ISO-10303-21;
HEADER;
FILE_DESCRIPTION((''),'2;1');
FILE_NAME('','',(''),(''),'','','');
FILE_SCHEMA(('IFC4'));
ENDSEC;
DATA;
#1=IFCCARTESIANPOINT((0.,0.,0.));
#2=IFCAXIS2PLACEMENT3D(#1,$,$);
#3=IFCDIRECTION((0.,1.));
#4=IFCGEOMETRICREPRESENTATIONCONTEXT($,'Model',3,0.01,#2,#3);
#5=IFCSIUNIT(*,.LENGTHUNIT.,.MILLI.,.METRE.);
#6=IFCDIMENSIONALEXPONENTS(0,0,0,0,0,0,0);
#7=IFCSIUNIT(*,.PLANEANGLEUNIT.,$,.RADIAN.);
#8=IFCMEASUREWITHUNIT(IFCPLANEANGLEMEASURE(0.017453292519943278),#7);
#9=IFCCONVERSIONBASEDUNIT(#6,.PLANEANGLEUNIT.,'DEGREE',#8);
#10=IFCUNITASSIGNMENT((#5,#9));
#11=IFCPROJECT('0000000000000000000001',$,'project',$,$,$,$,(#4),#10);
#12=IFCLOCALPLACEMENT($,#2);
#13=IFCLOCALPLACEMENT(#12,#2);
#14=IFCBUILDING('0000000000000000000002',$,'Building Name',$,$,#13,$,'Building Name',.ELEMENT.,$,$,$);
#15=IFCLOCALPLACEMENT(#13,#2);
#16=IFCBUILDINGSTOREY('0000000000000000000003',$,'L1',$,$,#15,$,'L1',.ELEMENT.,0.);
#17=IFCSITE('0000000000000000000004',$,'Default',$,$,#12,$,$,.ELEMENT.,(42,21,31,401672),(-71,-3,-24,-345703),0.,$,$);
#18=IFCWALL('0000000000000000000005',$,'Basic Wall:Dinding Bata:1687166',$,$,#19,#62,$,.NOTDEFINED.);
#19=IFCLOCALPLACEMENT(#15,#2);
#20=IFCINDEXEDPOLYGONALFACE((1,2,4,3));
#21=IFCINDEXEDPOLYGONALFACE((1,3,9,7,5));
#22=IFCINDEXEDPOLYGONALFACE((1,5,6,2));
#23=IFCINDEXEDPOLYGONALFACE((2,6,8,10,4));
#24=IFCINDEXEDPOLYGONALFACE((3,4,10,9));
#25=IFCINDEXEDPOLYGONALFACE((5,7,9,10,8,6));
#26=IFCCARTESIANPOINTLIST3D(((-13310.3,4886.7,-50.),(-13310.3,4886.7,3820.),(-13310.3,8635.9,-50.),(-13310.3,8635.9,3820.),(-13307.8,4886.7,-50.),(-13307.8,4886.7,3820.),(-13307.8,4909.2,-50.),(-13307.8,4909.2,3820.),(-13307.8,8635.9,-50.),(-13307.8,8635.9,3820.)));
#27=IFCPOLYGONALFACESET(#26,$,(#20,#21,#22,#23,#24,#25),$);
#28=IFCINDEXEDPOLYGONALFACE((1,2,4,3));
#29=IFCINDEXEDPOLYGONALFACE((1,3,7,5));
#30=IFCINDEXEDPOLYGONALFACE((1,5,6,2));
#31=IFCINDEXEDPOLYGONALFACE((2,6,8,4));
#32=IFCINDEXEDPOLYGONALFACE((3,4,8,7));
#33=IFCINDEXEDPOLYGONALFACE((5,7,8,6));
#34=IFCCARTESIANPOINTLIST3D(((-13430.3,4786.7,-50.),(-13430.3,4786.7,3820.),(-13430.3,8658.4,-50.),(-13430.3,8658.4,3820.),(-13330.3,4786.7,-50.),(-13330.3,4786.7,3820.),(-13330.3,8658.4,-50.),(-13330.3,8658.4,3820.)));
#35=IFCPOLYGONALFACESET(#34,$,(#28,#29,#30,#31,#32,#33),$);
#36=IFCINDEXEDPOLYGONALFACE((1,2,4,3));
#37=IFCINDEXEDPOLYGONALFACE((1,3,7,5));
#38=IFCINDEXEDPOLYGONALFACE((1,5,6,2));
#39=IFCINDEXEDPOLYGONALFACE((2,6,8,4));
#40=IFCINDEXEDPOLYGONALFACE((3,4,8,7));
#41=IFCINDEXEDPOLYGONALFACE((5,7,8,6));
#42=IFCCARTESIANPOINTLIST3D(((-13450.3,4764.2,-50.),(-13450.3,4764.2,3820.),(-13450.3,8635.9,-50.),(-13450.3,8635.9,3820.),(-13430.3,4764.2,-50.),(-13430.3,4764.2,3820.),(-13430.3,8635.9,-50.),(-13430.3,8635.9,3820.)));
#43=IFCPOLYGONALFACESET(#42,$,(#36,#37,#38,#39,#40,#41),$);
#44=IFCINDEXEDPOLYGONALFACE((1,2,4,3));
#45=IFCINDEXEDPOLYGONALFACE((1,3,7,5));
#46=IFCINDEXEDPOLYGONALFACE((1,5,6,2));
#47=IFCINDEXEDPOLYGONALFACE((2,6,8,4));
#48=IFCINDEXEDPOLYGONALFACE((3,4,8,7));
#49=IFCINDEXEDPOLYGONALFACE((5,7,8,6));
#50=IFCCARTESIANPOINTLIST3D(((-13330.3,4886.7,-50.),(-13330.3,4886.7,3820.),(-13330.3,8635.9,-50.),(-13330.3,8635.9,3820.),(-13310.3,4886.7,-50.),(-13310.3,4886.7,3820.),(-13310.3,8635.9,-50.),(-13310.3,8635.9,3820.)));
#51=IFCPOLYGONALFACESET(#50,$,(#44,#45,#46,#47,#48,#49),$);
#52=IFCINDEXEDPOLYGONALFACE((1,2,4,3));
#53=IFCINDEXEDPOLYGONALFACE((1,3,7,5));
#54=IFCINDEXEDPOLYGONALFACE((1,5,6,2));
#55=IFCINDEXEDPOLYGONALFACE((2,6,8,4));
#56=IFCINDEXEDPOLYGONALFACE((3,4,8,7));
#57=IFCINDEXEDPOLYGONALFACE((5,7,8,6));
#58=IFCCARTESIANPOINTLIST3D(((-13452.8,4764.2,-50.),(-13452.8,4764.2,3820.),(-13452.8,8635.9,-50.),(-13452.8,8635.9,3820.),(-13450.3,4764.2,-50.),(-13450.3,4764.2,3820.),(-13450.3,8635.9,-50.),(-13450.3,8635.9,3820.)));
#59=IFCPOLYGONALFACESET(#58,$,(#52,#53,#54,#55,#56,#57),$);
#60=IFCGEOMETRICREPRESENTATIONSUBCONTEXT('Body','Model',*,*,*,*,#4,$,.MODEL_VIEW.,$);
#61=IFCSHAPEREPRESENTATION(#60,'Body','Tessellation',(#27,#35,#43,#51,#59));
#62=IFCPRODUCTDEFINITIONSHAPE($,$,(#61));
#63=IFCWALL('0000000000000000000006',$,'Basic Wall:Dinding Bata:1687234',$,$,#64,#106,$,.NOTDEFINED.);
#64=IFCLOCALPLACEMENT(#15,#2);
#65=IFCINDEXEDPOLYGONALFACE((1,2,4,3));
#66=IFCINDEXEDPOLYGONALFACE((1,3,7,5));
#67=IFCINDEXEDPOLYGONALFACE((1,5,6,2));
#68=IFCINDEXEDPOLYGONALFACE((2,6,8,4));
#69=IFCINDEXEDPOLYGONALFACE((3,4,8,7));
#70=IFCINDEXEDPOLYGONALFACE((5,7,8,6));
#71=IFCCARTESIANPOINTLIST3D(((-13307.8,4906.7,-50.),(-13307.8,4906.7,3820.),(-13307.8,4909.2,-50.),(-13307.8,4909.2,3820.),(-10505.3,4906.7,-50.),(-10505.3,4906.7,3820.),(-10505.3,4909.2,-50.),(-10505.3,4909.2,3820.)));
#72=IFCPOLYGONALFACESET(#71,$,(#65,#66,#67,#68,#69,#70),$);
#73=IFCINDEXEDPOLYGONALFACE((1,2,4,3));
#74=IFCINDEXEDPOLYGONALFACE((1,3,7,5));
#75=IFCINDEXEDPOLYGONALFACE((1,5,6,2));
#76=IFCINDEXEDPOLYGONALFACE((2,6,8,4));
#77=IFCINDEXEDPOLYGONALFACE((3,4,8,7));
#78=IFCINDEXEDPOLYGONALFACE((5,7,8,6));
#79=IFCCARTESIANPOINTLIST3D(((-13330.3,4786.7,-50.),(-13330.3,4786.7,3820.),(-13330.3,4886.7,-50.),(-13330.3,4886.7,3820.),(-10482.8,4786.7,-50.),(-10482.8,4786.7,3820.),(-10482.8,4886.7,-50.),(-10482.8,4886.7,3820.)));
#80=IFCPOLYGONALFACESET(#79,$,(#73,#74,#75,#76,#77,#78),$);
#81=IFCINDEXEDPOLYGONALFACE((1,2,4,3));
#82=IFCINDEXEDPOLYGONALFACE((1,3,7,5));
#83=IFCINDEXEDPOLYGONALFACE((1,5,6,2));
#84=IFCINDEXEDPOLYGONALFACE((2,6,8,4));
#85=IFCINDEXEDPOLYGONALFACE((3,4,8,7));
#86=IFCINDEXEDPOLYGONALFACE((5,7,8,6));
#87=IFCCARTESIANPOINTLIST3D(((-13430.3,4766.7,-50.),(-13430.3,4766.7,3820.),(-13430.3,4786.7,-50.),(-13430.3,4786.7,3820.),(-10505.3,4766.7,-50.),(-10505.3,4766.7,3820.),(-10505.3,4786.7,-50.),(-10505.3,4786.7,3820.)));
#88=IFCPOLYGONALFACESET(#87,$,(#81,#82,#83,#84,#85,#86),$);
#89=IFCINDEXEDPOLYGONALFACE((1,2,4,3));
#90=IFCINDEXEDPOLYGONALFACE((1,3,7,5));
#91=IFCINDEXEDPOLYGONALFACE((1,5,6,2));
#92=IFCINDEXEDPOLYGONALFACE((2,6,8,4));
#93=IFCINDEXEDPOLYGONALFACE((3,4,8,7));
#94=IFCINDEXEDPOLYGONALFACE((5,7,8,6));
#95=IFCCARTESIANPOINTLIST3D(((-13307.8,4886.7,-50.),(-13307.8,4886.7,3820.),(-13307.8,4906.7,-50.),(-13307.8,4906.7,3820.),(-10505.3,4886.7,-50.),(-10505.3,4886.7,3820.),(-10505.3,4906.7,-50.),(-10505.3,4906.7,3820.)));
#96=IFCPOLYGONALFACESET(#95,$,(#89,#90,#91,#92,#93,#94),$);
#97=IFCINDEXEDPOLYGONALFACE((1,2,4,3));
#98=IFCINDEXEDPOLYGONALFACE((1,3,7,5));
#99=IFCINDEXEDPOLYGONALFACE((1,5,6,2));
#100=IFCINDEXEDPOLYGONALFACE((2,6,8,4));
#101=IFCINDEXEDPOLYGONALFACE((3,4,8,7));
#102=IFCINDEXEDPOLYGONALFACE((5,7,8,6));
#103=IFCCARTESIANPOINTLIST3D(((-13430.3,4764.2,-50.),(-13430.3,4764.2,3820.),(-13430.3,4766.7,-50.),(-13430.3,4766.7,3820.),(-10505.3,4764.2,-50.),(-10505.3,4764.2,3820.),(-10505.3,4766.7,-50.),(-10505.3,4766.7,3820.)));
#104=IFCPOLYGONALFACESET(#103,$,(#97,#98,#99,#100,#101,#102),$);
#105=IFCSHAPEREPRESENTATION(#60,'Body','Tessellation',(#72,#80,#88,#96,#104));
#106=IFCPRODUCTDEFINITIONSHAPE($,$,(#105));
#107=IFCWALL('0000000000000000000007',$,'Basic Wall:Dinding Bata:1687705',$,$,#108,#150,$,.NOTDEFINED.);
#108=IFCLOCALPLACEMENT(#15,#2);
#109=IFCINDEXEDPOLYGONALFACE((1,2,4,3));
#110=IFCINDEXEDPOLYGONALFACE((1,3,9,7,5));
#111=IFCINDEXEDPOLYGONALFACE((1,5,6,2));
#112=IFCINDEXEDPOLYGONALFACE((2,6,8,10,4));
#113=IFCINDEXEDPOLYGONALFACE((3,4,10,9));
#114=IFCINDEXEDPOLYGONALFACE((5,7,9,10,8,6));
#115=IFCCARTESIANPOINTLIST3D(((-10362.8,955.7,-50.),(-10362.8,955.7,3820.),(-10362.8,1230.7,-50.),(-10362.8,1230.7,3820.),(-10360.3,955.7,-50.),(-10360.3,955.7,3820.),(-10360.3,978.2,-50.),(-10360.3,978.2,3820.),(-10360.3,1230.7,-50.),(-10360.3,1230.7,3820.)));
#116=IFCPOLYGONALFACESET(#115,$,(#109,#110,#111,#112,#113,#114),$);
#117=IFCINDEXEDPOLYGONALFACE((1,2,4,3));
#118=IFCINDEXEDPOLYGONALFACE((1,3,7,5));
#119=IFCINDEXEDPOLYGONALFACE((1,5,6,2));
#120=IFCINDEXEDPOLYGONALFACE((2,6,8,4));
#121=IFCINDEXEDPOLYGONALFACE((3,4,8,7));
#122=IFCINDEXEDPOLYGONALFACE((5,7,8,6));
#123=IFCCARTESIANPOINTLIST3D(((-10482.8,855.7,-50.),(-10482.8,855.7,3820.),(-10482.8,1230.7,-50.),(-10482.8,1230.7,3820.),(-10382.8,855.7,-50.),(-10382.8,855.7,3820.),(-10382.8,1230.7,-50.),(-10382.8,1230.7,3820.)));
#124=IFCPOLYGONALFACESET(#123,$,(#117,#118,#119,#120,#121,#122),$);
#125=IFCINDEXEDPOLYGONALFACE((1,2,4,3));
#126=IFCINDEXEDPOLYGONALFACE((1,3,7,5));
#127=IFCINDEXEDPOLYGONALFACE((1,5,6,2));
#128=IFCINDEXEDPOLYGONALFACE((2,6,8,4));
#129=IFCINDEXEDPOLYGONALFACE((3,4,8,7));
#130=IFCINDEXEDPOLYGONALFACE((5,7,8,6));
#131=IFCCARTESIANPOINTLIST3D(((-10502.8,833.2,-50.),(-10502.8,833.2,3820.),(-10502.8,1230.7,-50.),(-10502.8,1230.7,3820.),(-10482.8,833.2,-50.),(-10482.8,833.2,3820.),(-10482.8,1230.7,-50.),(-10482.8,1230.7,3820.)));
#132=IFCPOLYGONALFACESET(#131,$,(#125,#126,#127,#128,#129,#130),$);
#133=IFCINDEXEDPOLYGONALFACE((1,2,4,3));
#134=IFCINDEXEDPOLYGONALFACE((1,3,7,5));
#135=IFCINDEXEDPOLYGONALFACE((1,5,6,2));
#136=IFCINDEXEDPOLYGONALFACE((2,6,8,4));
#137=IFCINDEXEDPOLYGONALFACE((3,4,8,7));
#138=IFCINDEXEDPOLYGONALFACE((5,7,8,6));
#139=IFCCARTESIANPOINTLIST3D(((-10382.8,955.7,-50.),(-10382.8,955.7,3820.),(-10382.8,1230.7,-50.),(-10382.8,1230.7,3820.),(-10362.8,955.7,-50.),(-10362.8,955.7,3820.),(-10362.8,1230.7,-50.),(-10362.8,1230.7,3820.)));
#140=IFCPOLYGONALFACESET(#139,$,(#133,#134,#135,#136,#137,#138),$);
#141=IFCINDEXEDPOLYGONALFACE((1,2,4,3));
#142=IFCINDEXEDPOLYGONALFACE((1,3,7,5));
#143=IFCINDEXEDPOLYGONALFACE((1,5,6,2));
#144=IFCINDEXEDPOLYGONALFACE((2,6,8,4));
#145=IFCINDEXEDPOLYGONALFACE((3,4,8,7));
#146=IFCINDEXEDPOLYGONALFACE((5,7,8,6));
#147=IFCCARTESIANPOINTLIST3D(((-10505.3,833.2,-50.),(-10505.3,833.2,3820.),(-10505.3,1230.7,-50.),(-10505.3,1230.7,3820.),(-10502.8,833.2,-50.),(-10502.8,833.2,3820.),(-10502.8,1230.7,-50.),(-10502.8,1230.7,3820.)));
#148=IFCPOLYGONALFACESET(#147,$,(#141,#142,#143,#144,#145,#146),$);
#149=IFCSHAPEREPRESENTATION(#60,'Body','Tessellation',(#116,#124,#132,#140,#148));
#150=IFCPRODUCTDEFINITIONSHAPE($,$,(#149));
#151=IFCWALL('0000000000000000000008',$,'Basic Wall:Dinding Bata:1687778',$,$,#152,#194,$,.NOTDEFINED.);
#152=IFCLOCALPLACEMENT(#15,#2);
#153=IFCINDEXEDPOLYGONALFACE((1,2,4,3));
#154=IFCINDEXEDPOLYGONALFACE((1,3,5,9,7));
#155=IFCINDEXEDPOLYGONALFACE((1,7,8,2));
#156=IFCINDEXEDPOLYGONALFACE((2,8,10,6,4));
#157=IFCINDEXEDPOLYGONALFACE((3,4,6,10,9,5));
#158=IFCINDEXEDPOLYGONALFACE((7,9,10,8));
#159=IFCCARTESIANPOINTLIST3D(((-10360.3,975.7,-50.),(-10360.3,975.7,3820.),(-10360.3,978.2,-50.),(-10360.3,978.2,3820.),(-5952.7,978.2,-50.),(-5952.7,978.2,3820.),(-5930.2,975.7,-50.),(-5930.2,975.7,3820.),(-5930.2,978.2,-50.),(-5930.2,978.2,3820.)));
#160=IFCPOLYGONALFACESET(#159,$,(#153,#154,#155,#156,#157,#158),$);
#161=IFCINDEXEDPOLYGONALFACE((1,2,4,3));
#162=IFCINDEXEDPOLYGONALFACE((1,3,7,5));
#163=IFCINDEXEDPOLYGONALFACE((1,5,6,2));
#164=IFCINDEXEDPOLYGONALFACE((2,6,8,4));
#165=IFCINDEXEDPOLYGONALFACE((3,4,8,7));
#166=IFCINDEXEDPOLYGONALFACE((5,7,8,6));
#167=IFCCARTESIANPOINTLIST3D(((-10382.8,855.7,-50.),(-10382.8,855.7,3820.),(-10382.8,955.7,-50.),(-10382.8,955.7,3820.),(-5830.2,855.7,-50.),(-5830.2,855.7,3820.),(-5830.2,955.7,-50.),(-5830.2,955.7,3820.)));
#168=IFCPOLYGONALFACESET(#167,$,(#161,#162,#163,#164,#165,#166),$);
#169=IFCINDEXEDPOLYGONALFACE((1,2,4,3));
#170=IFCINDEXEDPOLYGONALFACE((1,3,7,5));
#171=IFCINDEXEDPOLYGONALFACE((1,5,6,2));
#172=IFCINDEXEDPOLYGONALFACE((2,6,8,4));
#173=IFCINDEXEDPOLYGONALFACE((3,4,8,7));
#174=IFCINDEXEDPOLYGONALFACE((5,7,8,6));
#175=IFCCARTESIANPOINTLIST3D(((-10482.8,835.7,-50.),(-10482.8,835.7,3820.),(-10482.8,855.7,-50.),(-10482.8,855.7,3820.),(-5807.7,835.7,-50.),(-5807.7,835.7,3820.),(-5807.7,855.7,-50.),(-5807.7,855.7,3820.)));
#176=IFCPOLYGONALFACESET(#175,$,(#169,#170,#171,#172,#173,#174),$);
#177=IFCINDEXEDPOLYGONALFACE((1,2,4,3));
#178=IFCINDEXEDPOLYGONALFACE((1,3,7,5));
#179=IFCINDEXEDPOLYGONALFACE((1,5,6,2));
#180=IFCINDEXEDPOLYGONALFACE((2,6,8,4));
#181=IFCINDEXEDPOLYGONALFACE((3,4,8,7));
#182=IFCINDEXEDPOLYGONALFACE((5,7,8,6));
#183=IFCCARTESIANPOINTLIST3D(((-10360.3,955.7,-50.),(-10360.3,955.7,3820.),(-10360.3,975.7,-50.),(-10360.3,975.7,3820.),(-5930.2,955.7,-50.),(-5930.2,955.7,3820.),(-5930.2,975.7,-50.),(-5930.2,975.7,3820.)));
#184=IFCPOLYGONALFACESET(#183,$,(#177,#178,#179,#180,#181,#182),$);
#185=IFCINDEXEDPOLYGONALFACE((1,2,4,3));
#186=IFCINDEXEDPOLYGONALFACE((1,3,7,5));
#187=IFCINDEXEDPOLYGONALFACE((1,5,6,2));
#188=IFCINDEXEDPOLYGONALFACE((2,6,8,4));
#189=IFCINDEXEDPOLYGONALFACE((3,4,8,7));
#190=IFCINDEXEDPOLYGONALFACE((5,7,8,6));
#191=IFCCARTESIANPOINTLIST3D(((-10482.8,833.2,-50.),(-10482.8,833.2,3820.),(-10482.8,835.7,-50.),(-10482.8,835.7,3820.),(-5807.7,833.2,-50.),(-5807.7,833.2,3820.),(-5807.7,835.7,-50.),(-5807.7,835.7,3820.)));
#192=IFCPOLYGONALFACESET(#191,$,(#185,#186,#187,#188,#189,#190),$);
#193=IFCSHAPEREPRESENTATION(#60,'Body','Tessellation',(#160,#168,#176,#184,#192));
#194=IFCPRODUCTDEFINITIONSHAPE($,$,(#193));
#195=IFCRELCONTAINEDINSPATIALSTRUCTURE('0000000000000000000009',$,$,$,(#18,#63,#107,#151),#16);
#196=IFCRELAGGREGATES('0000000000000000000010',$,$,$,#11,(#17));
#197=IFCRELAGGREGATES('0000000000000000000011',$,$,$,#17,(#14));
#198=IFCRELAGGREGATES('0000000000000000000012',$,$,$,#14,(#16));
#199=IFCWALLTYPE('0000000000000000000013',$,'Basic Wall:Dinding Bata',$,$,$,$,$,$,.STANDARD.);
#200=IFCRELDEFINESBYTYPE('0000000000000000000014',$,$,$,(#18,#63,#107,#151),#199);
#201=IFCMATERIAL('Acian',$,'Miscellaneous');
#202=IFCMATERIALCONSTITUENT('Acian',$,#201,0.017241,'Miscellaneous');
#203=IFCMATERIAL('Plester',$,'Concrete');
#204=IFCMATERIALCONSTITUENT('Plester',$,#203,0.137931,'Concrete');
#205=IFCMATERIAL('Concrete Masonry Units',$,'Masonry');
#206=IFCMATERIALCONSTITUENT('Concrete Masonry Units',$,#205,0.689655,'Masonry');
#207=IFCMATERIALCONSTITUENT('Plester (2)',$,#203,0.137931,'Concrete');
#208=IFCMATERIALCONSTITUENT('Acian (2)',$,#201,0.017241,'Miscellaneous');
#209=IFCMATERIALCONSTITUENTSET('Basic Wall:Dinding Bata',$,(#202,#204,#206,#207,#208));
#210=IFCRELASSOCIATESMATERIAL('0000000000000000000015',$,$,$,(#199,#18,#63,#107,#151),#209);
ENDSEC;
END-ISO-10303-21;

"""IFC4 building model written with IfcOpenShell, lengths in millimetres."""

from ifc_helpers import new_model, entity, si_unit, converted_unit, direction, frame, origin, place, context, subcontext, project, spatial, indexed_curve, outline, extrude, material, constituent, constituent_set, type_object, element, save


model = new_model("IFC4")

# Units and contexts
model_context = context("Model", 3, precision=0.01, world=origin(), true_north=direction((0.0, 1.0)))
body_context = subcontext(model_context, "Body", "Model", "MODEL_VIEW")
ifc_project = project(units=[si_unit("LENGTHUNIT", "METRE", prefix="MILLI"), converted_unit("PLANEANGLEUNIT", "DEGREE", entity("IfcPlaneAngleMeasure", 0.017453292519943278), si_unit("PLANEANGLEUNIT", "RADIAN"), dimensions=[0, 0, 0, 0, 0, 0, 0])], contexts=[model_context])

# Site, building, storey
site_placement = place(None, origin())
site = spatial("IfcSite", under=ifc_project, at=site_placement, Name="Default", CompositionType="ELEMENT", RefLatitude=(42, 21, 31, 401672), RefLongitude=(-71, -3, -24, -345703), RefElevation=0.0)
building_placement = place(site_placement, origin())
building = spatial("IfcBuilding", under=site, at=building_placement, Name="Building Name", LongName="Building Name", CompositionType="ELEMENT")
storey_placement = place(building_placement, origin())
storey = spatial("IfcBuildingStorey", under=building, at=storey_placement, Name="L1", LongName="L1", CompositionType="ELEMENT", Elevation=0.0)

# Walls
ifc_material_1 = material(Name="Acian", Category="Miscellaneous")
ifc_constituent_1 = constituent(ifc_material_1, Name="Acian", Category="Miscellaneous", fraction=0.017241)
ifc_material_2 = material(Name="Plester", Category="Concrete")
ifc_constituent_2 = constituent(ifc_material_2, Name="Plester", Category="Concrete", fraction=0.137931)
ifc_material_3 = material(Name="Concrete Masonry Units", Category="Masonry")
ifc_constituent_3 = constituent(ifc_material_3, Name="Concrete Masonry Units", Category="Masonry", fraction=0.689655)
ifc_constituent_4 = constituent(ifc_material_2, Name="Plester (2)", Category="Concrete", fraction=0.137931)
ifc_constituent_5 = constituent(ifc_material_1, Name="Acian (2)", Category="Miscellaneous", fraction=0.017241)
ifc_constituent_set = constituent_set(constituents=[ifc_constituent_1, ifc_constituent_2, ifc_constituent_3, ifc_constituent_4, ifc_constituent_5], Name="Basic Wall:Dinding Bata")
wall_type = type_object("IfcWallType", Name="Basic Wall:Dinding Bata", PredefinedType="STANDARD", material=ifc_constituent_set)
wall_1_placement = place(storey_placement, frame((-13380.3, 8635.9, -50.0), z_axis=(0.0, 0.0, 1.0), x_axis=(0.0, -1.0, 0.0)))
element("IfcWall", 1, at=wall_1_placement, inside=storey, type_object=wall_type, material=ifc_constituent_set, Name="Basic Wall:Dinding Bata:1687166", PredefinedType="NOTDEFINED", context=body_context, shape_type="SweptSolid", body=[
    extrude(outline(indexed_curve([(-1481.7, -1.0), (2245.0, -1.0), (2245.0, 1.5), (-1504.2, 1.5), (-1504.2, -1.0), (-1481.7, -1.0)], self_intersect=False)), frame((2245.0, 71.5, 0.0), z_axis=(0.0, 0.0, 1.0), x_axis=(-1.0, 0.0, 0.0)), (0.0, 0.0, 1.0), 3870.0),
    extrude(outline(indexed_curve([(-1935.8, -50.0), (1935.8, -50.0), (1935.8, 50.0), (-1935.8, 50.0), (-1935.8, -50.0)], self_intersect=False)), frame((1913.3, 0.0, 0.0)), (0.0, 0.0, 1.0), 3870.0),
    extrude(outline(indexed_curve([(-1935.8, -10.0), (1935.8, -10.0), (1935.8, 10.0), (-1935.8, 10.0), (-1935.8, -10.0)], self_intersect=False)), frame((1935.8, -60.0, 0.0)), (0.0, 0.0, 1.0), 3870.0),
    extrude(outline(indexed_curve([(-1874.6, -10.0), (1874.6, -10.0), (1874.6, 10.0), (-1874.6, 10.0), (-1874.6, -10.0)], self_intersect=False)), frame((1874.6, 60.0, 0.0)), (0.0, 0.0, 1.0), 3870.0),
    extrude(outline(indexed_curve([(-1.3, -1935.8), (1.2, -1935.8), (1.3, 1935.8), (-1.2, 1935.8), (-1.3, -1935.8)], self_intersect=False)), frame((1935.8, -71.2, 0.0), z_axis=(0.0, 0.0, 1.0), x_axis=(0.0, 1.0, 0.0)), (0.0, 0.0, 1.0), 3870.0),
])
wall_2_placement = place(storey_placement, frame((-13307.8, 4836.7, -50.0)))
element("IfcWall", 2, at=wall_2_placement, inside=storey, type_object=wall_type, material=ifc_constituent_set, Name="Basic Wall:Dinding Bata:1687234", PredefinedType="NOTDEFINED", context=body_context, shape_type="SweptSolid", body=[
    extrude(outline(indexed_curve([(-1.3, -1401.2), (1.2, -1401.2), (1.3, 1401.2), (-1.2, 1401.2), (-1.3, -1401.2)], self_intersect=False)), frame((1401.2, 71.2, 0.0), z_axis=(0.0, 0.0, 1.0), x_axis=(0.0, -1.0, 0.0)), (0.0, 0.0, 1.0), 3870.0),
    extrude(outline(indexed_curve([(-1423.7, -50.0), (1423.7, -50.0), (1423.7, 50.0), (-1423.7, 50.0), (-1423.7, -50.0)], self_intersect=False)), frame((1401.2, 0.0, 0.0)), (0.0, 0.0, 1.0), 3870.0),
    extrude(outline(indexed_curve([(-1462.5, -10.0), (1462.5, -10.0), (1462.5, 10.0), (-1462.5, 10.0), (-1462.5, -10.0)], self_intersect=False)), frame((1340.0, -60.0, 0.0)), (0.0, 0.0, 1.0), 3870.0),
    extrude(outline(indexed_curve([(-1401.2, -10.0), (1401.2, -10.0), (1401.2, 10.0), (-1401.2, 10.0), (-1401.2, -10.0)], self_intersect=False)), frame((1401.2, 60.0, 0.0)), (0.0, 0.0, 1.0), 3870.0),
    extrude(outline(indexed_curve([(-1.3, -1462.5), (1.2, -1462.5), (1.3, 1462.5), (-1.2, 1462.5), (-1.3, -1462.5)], self_intersect=False)), frame((1340.0, -71.3, 0.0), z_axis=(0.0, 0.0, 1.0), x_axis=(0.0, 1.0, 0.0)), (0.0, 0.0, 1.0), 3870.0),
])
wall_3_placement = place(storey_placement, frame((-10432.8, 1230.7, -50.0), z_axis=(0.0, 0.0, 1.0), x_axis=(0.0, -1.0, 0.0)))
element("IfcWall", 3, at=wall_3_placement, inside=storey, type_object=wall_type, material=ifc_constituent_set, Name="Basic Wall:Dinding Bata:1687705", PredefinedType="NOTDEFINED", context=body_context, shape_type="SweptSolid", body=[
    extrude(outline(indexed_curve([(-92.0, -1.0), (160.5, -1.0), (160.5, 1.5), (-114.5, 1.5), (-114.5, -1.0), (-92.0, -1.0)], self_intersect=False)), frame((160.5, 71.5, 0.0), z_axis=(0.0, 0.0, 1.0), x_axis=(-1.0, 0.0, 0.0)), (0.0, 0.0, 1.0), 3870.0),
    extrude(outline(indexed_curve([(-187.5, -50.0), (187.5, -50.0), (187.5, 50.0), (-187.5, 50.0), (-187.5, -50.0)], self_intersect=False)), frame((187.5, 0.0, 0.0)), (0.0, 0.0, 1.0), 3870.0),
    extrude(outline(indexed_curve([(-198.8, -10.0), (198.8, -10.0), (198.8, 10.0), (-198.8, 10.0), (-198.8, -10.0)], self_intersect=False)), frame((198.8, -60.0, 0.0)), (0.0, 0.0, 1.0), 3870.0),
    extrude(outline(indexed_curve([(-137.5, -10.0), (137.5, -10.0), (137.5, 10.0), (-137.5, 10.0), (-137.5, -10.0)], self_intersect=False)), frame((137.5, 60.0, 0.0)), (0.0, 0.0, 1.0), 3870.0),
    extrude(outline(indexed_curve([(-1.2, -198.8), (1.2, -198.8), (1.2, 198.8), (-1.2, 198.8), (-1.2, -198.8)], self_intersect=False)), frame((198.8, -71.2, 0.0), z_axis=(0.0, 0.0, 1.0), x_axis=(0.0, 1.0, 0.0)), (0.0, 0.0, 1.0), 3870.0),
])
wall_4_placement = place(storey_placement, frame((-10360.3, 905.7, -50.0)))
element("IfcWall", 4, at=wall_4_placement, inside=storey, type_object=wall_type, material=ifc_constituent_set, Name="Basic Wall:Dinding Bata:1687778", PredefinedType="NOTDEFINED", context=body_context, shape_type="SweptSolid", body=[
    extrude(outline(indexed_curve([(-1754.0, -1.0), (2653.5, -1.0), (2653.5, 1.5), (-1776.5, 1.5), (-1776.5, -1.0), (-1754.0, -1.0)], self_intersect=False)), frame((2653.5, 71.5, 0.0), z_axis=(0.0, 0.0, 1.0), x_axis=(-1.0, 0.0, 0.0)), (0.0, 0.0, 1.0), 3870.0),
    extrude(outline(indexed_curve([(-2276.3, -50.0), (2276.3, -50.0), (2276.3, 50.0), (-2276.3, 50.0), (-2276.3, -50.0)], self_intersect=False)), frame((2253.8, 0.0, 0.0)), (0.0, 0.0, 1.0), 3870.0),
    extrude(outline(indexed_curve([(-2337.5, -10.0), (2337.5, -10.0), (2337.5, 10.0), (-2337.5, 10.0), (-2337.5, -10.0)], self_intersect=False)), frame((2215.0, -60.0, 0.0)), (0.0, 0.0, 1.0), 3870.0),
    extrude(outline(indexed_curve([(-2215.0, -10.0), (2215.0, -10.0), (2215.0, 10.0), (-2215.0, 10.0), (-2215.0, -10.0)], self_intersect=False)), frame((2215.0, 60.0, 0.0)), (0.0, 0.0, 1.0), 3870.0),
    extrude(outline(indexed_curve([(-1.3, -2337.5), (1.2, -2337.5), (1.3, 2337.5), (-1.2, 2337.5), (-1.3, -2337.5)], self_intersect=False)), frame((2215.0, -71.3, 0.0), z_axis=(0.0, 0.0, 1.0), x_axis=(0.0, 1.0, 0.0)), (0.0, 0.0, 1.0), 3870.0),
])

save(model, "model.ifc")
